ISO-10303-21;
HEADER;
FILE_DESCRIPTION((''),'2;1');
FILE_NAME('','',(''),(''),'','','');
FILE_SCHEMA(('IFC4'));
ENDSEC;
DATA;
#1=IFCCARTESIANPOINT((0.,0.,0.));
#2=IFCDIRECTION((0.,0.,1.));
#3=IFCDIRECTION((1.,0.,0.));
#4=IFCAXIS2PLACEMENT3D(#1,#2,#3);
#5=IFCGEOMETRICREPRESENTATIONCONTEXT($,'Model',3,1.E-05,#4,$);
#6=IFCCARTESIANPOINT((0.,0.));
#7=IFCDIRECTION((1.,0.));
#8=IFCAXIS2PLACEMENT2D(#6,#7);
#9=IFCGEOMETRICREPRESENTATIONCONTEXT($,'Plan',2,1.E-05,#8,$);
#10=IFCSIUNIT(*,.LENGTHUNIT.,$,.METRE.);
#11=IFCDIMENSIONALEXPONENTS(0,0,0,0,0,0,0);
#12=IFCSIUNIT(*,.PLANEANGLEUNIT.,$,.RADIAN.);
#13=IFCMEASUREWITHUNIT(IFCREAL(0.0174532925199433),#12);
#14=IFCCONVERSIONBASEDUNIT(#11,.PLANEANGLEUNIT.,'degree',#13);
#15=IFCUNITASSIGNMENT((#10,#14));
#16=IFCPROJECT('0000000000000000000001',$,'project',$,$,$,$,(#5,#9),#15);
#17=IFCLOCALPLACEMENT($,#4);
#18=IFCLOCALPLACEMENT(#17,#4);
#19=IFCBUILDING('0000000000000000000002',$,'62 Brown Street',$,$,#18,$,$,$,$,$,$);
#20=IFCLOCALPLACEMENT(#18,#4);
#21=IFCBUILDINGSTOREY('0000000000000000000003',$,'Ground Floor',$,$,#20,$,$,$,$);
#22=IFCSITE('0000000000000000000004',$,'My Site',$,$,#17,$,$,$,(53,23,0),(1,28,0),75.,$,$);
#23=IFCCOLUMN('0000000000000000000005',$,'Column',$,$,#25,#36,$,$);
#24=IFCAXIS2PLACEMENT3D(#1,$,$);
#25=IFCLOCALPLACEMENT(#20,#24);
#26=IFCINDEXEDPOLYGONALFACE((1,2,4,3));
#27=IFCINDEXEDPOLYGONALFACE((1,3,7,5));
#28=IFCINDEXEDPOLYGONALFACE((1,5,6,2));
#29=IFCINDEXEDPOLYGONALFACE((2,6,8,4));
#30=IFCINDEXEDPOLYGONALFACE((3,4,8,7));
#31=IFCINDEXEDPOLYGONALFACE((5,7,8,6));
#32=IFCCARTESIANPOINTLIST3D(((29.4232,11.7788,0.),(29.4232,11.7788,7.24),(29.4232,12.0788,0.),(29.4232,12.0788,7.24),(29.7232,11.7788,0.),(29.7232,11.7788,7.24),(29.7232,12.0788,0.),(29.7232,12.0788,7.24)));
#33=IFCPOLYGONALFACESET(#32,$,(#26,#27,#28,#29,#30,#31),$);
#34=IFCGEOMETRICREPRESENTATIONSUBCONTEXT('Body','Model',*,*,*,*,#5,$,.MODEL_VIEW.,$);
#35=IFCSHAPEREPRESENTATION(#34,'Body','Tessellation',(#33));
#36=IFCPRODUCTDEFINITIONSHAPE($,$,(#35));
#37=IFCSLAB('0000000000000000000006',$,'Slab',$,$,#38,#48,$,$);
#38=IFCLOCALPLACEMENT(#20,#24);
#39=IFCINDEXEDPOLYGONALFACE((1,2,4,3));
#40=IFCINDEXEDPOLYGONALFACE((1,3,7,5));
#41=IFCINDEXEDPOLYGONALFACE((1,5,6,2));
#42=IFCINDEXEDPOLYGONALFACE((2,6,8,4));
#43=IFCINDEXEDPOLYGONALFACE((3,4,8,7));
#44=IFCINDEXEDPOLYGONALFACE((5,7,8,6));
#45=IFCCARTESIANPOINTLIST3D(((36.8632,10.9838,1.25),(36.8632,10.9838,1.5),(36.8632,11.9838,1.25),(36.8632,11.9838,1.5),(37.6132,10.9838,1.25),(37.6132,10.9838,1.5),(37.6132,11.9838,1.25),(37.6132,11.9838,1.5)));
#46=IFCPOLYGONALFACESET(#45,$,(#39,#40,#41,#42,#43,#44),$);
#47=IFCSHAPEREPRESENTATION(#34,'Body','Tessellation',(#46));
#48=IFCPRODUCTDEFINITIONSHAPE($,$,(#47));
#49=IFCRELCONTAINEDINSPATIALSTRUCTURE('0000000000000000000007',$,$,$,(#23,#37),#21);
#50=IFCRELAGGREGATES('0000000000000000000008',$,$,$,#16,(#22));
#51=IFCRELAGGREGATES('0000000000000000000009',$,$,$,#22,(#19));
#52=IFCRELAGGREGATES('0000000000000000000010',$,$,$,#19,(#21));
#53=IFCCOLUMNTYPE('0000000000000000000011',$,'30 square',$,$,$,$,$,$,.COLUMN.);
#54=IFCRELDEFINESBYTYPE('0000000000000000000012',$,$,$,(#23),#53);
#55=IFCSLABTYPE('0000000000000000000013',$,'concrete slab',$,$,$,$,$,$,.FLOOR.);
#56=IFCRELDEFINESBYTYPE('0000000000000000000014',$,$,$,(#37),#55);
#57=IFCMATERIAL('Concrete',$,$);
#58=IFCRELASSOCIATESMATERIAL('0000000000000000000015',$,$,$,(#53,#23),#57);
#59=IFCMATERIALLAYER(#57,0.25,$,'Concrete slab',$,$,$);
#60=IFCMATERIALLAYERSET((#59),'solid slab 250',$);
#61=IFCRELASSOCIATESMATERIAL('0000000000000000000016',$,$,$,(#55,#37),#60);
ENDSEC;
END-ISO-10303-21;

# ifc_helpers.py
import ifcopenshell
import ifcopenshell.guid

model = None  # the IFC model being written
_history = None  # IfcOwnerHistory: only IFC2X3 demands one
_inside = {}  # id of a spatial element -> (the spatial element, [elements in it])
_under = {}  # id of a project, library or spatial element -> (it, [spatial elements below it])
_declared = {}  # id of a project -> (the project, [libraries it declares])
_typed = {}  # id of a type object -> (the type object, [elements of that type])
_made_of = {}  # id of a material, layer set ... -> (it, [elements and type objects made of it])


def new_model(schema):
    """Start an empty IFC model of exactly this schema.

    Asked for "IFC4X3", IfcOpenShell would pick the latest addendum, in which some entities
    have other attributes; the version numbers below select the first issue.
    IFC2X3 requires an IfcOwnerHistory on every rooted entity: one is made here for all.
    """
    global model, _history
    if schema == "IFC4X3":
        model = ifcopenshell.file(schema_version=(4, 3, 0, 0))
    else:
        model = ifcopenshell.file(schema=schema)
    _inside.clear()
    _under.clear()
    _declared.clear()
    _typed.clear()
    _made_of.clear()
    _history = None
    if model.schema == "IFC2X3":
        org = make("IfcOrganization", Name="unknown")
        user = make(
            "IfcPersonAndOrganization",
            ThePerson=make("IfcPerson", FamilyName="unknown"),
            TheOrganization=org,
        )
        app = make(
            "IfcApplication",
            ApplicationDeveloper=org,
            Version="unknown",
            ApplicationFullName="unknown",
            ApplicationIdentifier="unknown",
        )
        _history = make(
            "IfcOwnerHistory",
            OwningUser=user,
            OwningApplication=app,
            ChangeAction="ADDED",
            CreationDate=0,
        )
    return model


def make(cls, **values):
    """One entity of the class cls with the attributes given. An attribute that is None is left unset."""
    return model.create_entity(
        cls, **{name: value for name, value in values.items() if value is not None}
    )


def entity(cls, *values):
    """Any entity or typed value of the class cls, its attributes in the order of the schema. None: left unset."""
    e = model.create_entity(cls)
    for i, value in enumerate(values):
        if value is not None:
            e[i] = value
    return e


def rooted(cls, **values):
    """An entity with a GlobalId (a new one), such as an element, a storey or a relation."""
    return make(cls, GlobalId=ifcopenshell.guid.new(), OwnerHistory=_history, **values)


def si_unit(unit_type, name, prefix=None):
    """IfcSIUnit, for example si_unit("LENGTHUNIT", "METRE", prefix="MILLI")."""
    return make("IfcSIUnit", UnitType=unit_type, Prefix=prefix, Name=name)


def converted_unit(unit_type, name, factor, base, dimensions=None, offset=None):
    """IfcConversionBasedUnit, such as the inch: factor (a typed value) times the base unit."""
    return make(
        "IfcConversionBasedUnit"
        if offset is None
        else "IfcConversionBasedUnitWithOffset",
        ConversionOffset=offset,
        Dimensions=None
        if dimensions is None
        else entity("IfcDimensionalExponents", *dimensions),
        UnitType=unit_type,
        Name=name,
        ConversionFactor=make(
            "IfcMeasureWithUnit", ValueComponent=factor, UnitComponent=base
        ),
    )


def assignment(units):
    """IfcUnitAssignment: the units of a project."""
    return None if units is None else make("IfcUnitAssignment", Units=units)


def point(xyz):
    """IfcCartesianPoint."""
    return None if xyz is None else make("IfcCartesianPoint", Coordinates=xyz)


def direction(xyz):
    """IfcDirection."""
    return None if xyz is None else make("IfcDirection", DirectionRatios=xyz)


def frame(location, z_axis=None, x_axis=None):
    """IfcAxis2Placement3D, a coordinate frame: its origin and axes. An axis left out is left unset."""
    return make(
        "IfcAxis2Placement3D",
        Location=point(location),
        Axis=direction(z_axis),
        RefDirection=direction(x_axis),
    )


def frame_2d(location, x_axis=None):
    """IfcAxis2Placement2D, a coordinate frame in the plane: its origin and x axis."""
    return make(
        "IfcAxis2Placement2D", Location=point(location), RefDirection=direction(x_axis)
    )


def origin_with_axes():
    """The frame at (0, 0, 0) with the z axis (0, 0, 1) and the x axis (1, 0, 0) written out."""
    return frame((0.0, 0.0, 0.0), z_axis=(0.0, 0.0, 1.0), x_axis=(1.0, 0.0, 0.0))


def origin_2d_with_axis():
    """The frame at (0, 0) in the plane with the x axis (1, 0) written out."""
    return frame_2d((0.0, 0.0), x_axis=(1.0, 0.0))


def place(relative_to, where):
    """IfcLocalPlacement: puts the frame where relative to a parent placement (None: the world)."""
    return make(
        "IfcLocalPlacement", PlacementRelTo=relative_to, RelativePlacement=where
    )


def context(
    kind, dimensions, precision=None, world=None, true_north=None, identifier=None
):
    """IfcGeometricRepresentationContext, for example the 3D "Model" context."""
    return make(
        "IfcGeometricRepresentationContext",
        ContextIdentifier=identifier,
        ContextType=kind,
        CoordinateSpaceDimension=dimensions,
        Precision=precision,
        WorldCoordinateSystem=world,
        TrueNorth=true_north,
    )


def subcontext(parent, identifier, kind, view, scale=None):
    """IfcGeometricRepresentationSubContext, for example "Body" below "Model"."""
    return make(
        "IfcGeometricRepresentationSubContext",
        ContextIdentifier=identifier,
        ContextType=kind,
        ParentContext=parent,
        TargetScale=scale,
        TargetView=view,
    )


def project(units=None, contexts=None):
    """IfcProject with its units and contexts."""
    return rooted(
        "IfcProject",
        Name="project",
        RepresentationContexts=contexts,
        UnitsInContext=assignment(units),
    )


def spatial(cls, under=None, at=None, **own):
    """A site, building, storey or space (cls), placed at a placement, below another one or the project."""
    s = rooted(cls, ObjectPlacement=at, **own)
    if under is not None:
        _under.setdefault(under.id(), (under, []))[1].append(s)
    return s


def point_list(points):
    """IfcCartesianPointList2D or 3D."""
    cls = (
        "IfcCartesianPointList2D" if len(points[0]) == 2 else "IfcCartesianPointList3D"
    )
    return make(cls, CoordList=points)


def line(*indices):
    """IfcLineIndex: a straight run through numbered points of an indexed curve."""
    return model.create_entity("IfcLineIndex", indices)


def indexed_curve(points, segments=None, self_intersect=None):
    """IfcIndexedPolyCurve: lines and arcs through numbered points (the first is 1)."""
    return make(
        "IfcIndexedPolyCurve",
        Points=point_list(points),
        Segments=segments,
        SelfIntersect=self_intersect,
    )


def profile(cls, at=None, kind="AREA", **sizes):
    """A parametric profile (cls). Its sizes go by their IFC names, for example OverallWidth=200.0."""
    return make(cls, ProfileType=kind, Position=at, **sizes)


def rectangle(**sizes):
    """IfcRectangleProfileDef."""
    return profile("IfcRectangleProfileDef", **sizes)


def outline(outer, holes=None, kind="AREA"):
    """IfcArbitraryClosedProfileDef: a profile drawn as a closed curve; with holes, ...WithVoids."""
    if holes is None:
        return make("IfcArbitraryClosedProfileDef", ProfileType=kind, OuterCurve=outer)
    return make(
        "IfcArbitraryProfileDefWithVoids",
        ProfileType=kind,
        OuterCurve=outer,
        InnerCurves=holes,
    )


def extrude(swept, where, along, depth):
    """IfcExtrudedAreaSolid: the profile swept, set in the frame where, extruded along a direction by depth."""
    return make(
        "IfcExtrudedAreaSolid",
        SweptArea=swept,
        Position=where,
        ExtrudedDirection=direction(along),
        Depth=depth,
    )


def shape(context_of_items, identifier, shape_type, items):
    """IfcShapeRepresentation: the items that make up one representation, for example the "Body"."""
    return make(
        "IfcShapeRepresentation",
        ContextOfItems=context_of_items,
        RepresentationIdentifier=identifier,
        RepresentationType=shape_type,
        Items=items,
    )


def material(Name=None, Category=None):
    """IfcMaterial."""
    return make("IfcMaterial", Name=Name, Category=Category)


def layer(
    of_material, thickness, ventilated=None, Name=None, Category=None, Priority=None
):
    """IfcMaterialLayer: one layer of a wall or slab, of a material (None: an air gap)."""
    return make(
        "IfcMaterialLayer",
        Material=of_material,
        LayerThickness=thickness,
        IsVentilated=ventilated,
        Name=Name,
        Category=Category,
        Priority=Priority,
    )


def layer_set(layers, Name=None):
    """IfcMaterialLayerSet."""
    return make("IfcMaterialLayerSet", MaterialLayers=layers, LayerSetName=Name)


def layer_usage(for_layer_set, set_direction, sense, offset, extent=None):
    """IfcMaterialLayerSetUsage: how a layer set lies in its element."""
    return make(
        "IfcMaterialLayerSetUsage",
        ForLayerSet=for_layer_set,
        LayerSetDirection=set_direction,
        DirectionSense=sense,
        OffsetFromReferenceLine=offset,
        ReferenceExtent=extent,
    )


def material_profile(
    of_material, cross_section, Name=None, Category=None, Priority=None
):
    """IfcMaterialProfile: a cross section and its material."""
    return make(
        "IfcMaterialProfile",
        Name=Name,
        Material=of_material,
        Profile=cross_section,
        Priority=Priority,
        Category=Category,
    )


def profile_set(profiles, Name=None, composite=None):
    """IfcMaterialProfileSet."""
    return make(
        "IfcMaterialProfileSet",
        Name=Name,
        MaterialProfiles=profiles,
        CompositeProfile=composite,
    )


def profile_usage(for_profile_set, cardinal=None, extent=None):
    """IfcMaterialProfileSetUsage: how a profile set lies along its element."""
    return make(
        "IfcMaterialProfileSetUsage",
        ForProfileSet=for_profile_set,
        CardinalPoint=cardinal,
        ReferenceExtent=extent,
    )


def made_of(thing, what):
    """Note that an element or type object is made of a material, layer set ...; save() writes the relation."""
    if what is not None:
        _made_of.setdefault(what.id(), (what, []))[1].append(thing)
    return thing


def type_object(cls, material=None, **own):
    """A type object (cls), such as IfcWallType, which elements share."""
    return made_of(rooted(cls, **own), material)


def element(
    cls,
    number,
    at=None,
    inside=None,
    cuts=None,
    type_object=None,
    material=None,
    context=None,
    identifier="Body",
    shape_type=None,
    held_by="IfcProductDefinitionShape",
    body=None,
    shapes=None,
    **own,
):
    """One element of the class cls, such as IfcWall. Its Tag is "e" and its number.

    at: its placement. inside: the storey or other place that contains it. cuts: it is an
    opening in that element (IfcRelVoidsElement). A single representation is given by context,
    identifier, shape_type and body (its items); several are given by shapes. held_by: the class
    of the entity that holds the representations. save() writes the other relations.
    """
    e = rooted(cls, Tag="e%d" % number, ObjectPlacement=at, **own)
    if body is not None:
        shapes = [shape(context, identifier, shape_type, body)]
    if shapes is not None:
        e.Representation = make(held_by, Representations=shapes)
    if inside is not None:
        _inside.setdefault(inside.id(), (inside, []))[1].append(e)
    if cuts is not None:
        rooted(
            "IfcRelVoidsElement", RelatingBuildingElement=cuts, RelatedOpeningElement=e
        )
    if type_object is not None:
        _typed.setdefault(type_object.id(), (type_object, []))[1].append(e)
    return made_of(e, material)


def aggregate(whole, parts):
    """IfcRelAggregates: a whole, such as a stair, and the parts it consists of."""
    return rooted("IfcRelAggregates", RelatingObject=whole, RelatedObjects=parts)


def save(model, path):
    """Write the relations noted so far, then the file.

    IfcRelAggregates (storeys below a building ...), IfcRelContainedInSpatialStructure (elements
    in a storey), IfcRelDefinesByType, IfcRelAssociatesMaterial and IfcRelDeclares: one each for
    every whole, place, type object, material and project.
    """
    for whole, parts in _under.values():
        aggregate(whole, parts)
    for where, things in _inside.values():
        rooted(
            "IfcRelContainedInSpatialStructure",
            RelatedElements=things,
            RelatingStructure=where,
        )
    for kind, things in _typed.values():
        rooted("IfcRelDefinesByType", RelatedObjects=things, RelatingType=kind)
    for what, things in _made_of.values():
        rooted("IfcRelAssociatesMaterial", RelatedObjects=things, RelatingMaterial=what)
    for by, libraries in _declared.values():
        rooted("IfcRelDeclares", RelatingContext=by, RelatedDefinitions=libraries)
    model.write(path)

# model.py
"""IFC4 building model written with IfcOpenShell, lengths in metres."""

from ifc_helpers import new_model, entity, si_unit, converted_unit, frame, origin_with_axes, origin_2d_with_axis, place, context, subcontext, project, spatial, line, indexed_curve, rectangle, outline, extrude, material, layer, layer_set, layer_usage, material_profile, profile_set, profile_usage, type_object, element, save


model = new_model("IFC4")

# Units and contexts
model_context = context("Model", 3, precision=1e-05, world=origin_with_axes())
plan_context = context("Plan", 2, precision=1e-05, world=origin_2d_with_axis())
body_context_1 = subcontext(model_context, "Body", "Model", "MODEL_VIEW")
ifc_project = project(units=[si_unit("LENGTHUNIT", "METRE"), converted_unit("PLANEANGLEUNIT", "degree", entity("IfcReal", 0.0174532925199433), si_unit("PLANEANGLEUNIT", "RADIAN"), dimensions=[0, 0, 0, 0, 0, 0, 0])], contexts=[model_context, plan_context])

# Site, building, storey
site_placement = place(None, origin_with_axes())
site = spatial("IfcSite", under=ifc_project, at=site_placement, Name="My Site", RefLatitude=(53, 23, 0), RefLongitude=(1, 28, 0), RefElevation=75.0)
building_placement = place(site_placement, origin_with_axes())
building = spatial("IfcBuilding", under=site, at=building_placement, Name="62 Brown Street")
storey_placement = place(building_placement, origin_with_axes())
storey = spatial("IfcBuildingStorey", under=building, at=storey_placement, Name="Ground Floor")

# Column
ifc_material_1 = material(Name="Concrete")
ifc_material_profile_1 = material_profile(ifc_material_1, rectangle(XDim=0.3, YDim=0.3))
ifc_profile_set_1 = profile_set([ifc_material_profile_1])
ifc_profile_usage_1 = profile_usage(ifc_profile_set_1, cardinal=5)
column_type = type_object("IfcColumnType", Name="30 square", PredefinedType="COLUMN", material=ifc_profile_set_1)
column_placement = place(storey_placement, frame((29.5732, 11.9288, 0.0), z_axis=(0.0, 0.0, 1.0), x_axis=(1.0, 0.0, 0.0)))
element("IfcColumn", 1, at=column_placement, inside=storey, type_object=column_type, material=ifc_profile_usage_1, Name="Column", context=body_context_1, shape_type="SweptSolid", body=[
    extrude(rectangle(XDim=0.3, YDim=0.3), origin_with_axes(), (0.0, 0.0, 1.0), 7.24),
])

# Slab
ifc_layer_1 = layer(ifc_material_1, 0.25, Name="Concrete slab")
ifc_layer_set_1 = layer_set([ifc_layer_1], Name="solid slab 250")
ifc_layer_usage_1 = layer_usage(ifc_layer_set_1, "AXIS3", "POSITIVE", 0.0)
slab_type = type_object("IfcSlabType", Name="concrete slab", PredefinedType="FLOOR", material=ifc_layer_set_1)
slab_placement = place(storey_placement, frame((36.8632, 10.9838, 1.25), z_axis=(0.0, 0.0, 1.0), x_axis=(1.0, 0.0, 0.0)))
element("IfcSlab", 2, at=slab_placement, inside=storey, type_object=slab_type, material=ifc_layer_usage_1, Name="Slab", context=body_context_1, shape_type="SweptSolid", body=[
    extrude(outline(indexed_curve([(0.0, 0.0), (0.75, 0.0), (0.75, 1.0), (0.0, 1.0)], segments=[line(4, 1), line(1, 2), line(2, 3), line(3, 4)], self_intersect=False)), None, (0.0, 0.0, 1.0), 0.25),
])

save(model, "model.ifc")
